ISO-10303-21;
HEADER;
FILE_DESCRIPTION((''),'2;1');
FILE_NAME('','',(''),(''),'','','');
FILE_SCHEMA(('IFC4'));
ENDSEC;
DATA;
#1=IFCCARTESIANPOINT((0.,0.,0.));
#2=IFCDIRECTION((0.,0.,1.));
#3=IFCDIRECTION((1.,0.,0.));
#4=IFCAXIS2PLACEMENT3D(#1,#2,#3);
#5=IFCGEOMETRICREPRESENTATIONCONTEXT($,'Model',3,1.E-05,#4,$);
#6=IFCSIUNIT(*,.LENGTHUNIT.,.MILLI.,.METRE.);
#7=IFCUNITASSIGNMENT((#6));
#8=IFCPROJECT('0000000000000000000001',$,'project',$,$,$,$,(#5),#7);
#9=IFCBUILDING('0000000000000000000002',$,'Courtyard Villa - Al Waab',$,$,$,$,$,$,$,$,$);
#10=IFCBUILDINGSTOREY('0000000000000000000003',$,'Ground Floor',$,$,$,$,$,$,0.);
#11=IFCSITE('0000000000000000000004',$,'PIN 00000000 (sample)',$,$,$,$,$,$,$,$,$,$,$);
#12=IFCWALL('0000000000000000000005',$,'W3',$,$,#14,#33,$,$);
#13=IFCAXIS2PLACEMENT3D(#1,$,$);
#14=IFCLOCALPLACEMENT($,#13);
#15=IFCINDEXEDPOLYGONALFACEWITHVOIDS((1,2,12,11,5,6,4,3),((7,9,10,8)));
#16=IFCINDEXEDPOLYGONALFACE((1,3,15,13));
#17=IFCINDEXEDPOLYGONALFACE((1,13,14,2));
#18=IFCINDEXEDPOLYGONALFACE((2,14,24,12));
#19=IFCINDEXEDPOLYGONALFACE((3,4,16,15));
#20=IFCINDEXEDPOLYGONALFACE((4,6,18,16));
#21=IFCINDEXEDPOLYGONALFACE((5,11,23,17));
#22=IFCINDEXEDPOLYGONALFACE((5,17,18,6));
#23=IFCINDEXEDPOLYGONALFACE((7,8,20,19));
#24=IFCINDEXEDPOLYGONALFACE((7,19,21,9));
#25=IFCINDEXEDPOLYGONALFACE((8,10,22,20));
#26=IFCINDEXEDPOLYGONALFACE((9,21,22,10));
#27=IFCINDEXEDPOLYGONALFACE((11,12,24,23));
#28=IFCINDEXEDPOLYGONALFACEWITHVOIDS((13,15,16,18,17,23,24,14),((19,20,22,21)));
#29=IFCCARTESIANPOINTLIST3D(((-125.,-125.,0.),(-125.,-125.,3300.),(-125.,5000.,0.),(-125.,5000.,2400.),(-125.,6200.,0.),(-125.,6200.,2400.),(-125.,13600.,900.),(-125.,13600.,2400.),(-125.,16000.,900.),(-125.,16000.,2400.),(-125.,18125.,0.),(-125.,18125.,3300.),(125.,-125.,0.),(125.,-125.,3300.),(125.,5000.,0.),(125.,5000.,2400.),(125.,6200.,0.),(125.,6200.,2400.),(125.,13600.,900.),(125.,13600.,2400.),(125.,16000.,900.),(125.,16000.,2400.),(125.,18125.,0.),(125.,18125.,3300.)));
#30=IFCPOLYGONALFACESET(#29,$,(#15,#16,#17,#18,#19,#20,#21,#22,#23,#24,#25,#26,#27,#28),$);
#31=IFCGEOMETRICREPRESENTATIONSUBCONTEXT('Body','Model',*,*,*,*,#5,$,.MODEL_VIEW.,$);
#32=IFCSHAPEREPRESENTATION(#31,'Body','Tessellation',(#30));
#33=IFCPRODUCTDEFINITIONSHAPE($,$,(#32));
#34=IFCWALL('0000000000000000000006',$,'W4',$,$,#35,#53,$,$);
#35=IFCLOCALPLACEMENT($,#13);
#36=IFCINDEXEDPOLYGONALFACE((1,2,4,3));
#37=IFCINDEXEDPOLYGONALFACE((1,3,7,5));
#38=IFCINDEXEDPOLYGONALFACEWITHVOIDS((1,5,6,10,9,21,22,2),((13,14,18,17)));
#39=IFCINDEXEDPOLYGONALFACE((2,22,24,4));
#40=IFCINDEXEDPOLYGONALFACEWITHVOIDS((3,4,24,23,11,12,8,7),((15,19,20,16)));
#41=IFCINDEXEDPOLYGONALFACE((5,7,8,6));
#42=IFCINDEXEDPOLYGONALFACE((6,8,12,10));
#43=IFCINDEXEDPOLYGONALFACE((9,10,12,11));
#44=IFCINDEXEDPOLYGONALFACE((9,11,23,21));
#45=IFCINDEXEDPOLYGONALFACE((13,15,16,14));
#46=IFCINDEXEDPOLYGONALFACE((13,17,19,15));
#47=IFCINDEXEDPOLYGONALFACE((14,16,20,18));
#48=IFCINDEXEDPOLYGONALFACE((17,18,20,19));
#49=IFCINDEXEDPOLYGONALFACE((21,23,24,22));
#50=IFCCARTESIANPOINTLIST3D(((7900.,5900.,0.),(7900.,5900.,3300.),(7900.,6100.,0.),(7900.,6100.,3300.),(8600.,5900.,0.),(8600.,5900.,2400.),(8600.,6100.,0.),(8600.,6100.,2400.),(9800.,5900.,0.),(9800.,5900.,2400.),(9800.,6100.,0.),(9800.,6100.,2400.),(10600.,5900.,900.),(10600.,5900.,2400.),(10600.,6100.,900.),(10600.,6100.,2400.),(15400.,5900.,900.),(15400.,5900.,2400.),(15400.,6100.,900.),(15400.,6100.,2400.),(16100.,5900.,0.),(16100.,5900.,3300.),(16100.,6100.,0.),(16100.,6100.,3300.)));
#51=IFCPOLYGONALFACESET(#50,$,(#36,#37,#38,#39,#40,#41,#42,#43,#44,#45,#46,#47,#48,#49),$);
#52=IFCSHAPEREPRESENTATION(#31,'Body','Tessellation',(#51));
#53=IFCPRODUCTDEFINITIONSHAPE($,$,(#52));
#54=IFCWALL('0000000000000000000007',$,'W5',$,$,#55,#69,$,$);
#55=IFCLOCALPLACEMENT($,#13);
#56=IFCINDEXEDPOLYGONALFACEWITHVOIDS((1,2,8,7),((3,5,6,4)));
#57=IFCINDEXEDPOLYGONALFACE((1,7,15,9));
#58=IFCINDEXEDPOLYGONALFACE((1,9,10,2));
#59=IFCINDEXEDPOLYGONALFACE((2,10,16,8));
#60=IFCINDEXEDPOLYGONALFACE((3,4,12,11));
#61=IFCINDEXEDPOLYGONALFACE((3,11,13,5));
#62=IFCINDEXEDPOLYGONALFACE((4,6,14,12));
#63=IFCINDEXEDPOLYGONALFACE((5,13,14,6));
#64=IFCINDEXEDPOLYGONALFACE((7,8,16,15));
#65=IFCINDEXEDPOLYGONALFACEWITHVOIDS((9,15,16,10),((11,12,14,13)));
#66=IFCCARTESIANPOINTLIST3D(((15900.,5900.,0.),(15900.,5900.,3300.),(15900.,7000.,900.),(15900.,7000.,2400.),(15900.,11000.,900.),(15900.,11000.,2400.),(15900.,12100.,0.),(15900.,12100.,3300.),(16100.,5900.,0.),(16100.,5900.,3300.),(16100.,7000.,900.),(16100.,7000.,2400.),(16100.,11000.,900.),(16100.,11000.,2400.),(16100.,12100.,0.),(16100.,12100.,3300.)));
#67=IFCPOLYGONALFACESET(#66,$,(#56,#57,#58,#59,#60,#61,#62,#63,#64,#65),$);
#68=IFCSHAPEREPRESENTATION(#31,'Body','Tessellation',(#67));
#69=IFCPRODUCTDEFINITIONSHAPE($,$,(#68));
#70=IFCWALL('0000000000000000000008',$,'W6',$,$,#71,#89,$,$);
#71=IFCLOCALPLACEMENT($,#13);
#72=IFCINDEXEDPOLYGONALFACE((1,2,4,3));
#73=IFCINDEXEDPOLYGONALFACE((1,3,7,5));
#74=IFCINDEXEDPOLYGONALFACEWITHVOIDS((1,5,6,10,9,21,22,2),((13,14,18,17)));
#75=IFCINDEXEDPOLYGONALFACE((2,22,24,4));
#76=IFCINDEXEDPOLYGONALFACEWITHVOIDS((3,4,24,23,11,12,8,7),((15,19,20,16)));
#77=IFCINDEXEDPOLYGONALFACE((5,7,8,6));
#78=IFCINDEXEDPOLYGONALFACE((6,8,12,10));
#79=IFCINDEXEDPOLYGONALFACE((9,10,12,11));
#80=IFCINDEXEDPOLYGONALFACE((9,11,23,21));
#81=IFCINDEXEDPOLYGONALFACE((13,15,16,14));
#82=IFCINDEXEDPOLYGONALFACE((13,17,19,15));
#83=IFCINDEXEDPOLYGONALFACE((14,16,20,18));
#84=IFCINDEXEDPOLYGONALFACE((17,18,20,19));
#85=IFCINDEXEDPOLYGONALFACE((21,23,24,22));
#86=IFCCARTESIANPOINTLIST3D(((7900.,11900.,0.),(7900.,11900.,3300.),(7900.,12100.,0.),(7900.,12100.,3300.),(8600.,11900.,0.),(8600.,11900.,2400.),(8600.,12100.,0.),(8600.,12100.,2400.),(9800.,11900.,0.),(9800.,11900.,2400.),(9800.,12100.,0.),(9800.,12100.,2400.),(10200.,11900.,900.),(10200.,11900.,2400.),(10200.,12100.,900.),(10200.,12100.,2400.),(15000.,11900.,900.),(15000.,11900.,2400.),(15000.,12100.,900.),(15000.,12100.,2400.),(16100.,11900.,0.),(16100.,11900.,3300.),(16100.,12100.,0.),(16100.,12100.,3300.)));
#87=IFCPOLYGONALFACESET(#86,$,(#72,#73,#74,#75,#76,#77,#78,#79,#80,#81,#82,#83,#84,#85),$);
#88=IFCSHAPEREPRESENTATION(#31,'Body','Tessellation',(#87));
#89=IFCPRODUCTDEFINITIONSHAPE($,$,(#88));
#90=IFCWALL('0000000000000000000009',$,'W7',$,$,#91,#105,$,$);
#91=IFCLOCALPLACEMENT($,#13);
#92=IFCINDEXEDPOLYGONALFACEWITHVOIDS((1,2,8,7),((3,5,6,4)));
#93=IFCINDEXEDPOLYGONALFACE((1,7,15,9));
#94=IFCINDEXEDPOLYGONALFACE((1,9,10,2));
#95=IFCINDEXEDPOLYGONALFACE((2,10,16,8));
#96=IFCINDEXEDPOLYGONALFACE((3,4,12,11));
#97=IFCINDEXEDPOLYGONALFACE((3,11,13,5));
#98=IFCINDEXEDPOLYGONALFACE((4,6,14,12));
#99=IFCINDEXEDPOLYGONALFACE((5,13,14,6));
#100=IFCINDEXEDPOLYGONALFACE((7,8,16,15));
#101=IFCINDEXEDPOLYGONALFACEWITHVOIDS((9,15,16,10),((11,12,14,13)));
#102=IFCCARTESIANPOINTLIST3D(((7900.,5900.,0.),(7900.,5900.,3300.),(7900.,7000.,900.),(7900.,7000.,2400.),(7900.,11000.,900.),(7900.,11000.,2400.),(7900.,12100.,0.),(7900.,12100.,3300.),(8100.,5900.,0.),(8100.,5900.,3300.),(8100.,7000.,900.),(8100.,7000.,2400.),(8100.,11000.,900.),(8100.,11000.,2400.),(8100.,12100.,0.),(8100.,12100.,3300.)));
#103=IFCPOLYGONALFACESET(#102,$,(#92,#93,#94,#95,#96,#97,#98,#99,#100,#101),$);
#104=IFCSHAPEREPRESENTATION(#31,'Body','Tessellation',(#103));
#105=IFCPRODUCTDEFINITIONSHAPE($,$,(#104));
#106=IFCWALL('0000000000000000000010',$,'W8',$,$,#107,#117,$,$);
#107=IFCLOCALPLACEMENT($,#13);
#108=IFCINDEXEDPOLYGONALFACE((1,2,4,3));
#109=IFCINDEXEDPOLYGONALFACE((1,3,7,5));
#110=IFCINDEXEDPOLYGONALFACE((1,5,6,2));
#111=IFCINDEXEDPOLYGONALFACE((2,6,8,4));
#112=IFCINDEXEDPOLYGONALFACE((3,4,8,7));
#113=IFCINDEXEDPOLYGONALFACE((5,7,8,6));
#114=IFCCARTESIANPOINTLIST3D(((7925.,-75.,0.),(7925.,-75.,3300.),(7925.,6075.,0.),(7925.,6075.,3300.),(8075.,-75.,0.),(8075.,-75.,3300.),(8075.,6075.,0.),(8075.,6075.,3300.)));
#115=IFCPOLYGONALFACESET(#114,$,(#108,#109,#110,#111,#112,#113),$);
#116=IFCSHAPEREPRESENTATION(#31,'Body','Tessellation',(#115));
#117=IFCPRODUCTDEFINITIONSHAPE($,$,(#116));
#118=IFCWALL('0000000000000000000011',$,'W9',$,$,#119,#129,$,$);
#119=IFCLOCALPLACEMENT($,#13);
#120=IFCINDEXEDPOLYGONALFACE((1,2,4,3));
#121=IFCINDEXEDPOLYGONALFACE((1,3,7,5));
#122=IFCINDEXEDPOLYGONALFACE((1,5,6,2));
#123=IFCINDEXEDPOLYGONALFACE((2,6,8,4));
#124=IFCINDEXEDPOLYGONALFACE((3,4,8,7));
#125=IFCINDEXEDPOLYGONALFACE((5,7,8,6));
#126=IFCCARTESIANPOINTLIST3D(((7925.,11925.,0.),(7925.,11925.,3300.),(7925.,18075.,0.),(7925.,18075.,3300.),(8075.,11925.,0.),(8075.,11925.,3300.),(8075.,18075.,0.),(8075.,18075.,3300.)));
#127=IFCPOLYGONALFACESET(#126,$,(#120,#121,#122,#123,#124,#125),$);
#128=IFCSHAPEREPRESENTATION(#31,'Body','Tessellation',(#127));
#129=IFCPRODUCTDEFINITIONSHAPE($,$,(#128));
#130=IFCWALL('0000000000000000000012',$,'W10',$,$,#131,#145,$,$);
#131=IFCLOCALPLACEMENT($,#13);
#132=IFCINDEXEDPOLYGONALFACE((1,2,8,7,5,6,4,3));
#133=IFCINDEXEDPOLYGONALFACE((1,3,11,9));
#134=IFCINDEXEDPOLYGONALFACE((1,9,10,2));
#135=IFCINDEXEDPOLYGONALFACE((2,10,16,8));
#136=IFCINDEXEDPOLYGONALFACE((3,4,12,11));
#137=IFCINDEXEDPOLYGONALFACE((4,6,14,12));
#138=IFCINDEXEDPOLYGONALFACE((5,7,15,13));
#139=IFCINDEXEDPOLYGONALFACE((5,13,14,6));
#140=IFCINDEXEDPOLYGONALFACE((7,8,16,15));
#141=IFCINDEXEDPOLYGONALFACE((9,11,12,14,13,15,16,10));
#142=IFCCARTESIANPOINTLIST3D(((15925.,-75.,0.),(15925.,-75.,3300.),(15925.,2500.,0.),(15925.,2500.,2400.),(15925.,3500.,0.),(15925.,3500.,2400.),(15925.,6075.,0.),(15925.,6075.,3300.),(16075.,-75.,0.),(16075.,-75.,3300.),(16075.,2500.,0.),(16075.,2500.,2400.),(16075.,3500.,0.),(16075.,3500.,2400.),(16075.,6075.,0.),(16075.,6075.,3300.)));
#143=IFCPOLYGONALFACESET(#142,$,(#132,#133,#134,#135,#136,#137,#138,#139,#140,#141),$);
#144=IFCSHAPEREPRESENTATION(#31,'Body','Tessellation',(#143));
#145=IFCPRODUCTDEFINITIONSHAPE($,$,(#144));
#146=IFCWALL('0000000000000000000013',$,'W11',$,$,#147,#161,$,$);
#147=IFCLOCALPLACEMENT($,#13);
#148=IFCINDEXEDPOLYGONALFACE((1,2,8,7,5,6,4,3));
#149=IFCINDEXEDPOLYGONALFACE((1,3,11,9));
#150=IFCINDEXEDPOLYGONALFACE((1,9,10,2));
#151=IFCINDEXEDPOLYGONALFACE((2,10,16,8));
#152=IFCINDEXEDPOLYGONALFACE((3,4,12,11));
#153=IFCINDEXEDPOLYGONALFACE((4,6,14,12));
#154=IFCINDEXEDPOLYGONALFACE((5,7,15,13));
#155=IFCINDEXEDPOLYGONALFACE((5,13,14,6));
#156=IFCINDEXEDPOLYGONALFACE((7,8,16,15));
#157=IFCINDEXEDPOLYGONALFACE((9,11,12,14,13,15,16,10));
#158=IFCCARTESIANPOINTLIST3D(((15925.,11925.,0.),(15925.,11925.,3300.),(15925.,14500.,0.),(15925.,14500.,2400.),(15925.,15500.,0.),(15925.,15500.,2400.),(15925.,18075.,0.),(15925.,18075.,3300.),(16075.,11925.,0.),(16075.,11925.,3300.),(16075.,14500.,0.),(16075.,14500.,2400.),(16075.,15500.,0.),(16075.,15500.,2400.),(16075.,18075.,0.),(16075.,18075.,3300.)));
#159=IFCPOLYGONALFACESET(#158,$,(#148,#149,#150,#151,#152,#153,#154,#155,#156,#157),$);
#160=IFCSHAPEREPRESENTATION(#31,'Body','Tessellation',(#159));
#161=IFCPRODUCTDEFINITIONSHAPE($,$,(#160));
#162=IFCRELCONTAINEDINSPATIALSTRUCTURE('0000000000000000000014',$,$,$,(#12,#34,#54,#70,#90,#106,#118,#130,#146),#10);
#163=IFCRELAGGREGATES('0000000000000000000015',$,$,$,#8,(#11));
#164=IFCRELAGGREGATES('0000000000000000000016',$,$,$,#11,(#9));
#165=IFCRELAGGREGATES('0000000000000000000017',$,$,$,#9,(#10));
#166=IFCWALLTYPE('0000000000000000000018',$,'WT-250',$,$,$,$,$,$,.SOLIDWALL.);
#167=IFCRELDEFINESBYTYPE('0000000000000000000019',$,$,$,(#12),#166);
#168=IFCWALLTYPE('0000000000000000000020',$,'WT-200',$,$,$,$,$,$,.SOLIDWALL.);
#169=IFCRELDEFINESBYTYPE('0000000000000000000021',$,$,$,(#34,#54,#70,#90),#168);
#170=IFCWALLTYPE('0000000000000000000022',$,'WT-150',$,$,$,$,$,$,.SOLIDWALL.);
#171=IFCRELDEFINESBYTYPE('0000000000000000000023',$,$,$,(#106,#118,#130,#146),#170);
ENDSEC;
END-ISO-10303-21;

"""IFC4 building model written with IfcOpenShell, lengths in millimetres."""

from ifc_helpers import new_model, si_unit, frame, origin_with_axes, place, context, subcontext, project, spatial, indexed_curve, outline, extrude, type_object, element, save


model = new_model("IFC4")

# Units and contexts
model_context = context("Model", 3, precision=1e-05, world=origin_with_axes())
body_context = subcontext(model_context, "Body", "Model", "MODEL_VIEW")
ifc_project = project(units=[si_unit("LENGTHUNIT", "METRE", prefix="MILLI")], contexts=[model_context])

# Site, building, storey
site = spatial("IfcSite", under=ifc_project, Name="PIN 00000000 (sample)")
building = spatial("IfcBuilding", under=site, Name="Courtyard Villa - Al Waab")
storey = spatial("IfcBuildingStorey", under=building, Name="Ground Floor", Elevation=0.0)

# Walls, openings
wall_type_1 = type_object("IfcWallType", Name="WT-250", PredefinedType="SOLIDWALL")
wall_1_placement = place(None, frame((-125.0, 18125.0, 0.0), z_axis=(0.0, 0.0, 1.0), x_axis=(0.0, -1.0, 0.0)))
wall_1 = element("IfcWall", 1, at=wall_1_placement, inside=storey, type_object=wall_type_1, Name="W3", context=body_context, shape_type="SweptSolid", body=[
    extrude(outline(indexed_curve([(0.0, 0.0), (0.0, 250.0), (18250.0, 250.0), (18250.0, 0.0), (0.0, 0.0)], self_intersect=False)), origin_with_axes(), (0.0, 0.0, 1.0), 3300.0),
])
opening_1_placement = place(wall_1_placement, frame((2125.0, -100.0, 900.0), z_axis=(0.0, 0.0, 1.0), x_axis=(1.0, 0.0, 0.0)))
element("IfcOpeningElement", 2, at=opening_1_placement, cuts=wall_1, context=body_context, shape_type="SweptSolid", body=[
    extrude(outline(indexed_curve([(0.0, 0.0), (0.0, 450.0), (2400.0, 450.0), (2400.0, 0.0), (0.0, 0.0)], self_intersect=False)), origin_with_axes(), (0.0, 0.0, 1.0), 1500.0),
])
opening_2_placement = place(wall_1_placement, frame((11925.0, -100.0, 0.0), z_axis=(0.0, 0.0, 1.0), x_axis=(1.0, 0.0, 0.0)))
element("IfcOpeningElement", 3, at=opening_2_placement, cuts=wall_1, context=body_context, shape_type="SweptSolid", body=[
    extrude(outline(indexed_curve([(0.0, 0.0), (0.0, 450.0), (1200.0, 450.0), (1200.0, 0.0), (0.0, 0.0)], self_intersect=False)), origin_with_axes(), (0.0, 0.0, 1.0), 2400.0),
])
wall_type_2 = type_object("IfcWallType", Name="WT-200", PredefinedType="SOLIDWALL")
wall_2_placement = place(None, frame((7900.0, 5900.0, 0.0), z_axis=(0.0, 0.0, 1.0), x_axis=(1.0, 0.0, 0.0)))
wall_2 = element("IfcWall", 4, at=wall_2_placement, inside=storey, type_object=wall_type_2, Name="W4", context=body_context, shape_type="SweptSolid", body=[
    extrude(outline(indexed_curve([(0.0, 0.0), (0.0, 200.0), (8200.0, 200.0), (8200.0, 0.0), (0.0, 0.0)], self_intersect=False)), origin_with_axes(), (0.0, 0.0, 1.0), 3300.0),
])
opening_3_placement = place(wall_2_placement, frame((700.0, -100.0, 0.0), z_axis=(0.0, 0.0, 1.0), x_axis=(1.0, 0.0, 0.0)))
element("IfcOpeningElement", 5, at=opening_3_placement, cuts=wall_2, context=body_context, shape_type="SweptSolid", body=[
    extrude(outline(indexed_curve([(0.0, 0.0), (0.0, 400.0), (1200.0, 400.0), (1200.0, 0.0), (0.0, 0.0)], self_intersect=False)), origin_with_axes(), (0.0, 0.0, 1.0), 2400.0),
])
opening_4_placement = place(wall_2_placement, frame((2700.0, -100.0, 900.0), z_axis=(0.0, 0.0, 1.0), x_axis=(1.0, 0.0, 0.0)))
element("IfcOpeningElement", 6, at=opening_4_placement, cuts=wall_2, context=body_context, shape_type="SweptSolid", body=[
    extrude(outline(indexed_curve([(0.0, 0.0), (0.0, 400.0), (4800.0, 400.0), (4800.0, 0.0), (0.0, 0.0)], self_intersect=False)), origin_with_axes(), (0.0, 0.0, 1.0), 1500.0),
])

# Wall, opening
wall_3_placement = place(None, frame((16100.0, 5900.0, 0.0), z_axis=(0.0, 0.0, 1.0), x_axis=(0.0, 1.0, 0.0)))
wall_3 = element("IfcWall", 7, at=wall_3_placement, inside=storey, type_object=wall_type_2, Name="W5", context=body_context, shape_type="SweptSolid", body=[
    extrude(outline(indexed_curve([(0.0, 0.0), (0.0, 200.0), (6200.0, 200.0), (6200.0, 0.0), (0.0, 0.0)], self_intersect=False)), origin_with_axes(), (0.0, 0.0, 1.0), 3300.0),
])
opening_5_placement = place(wall_3_placement, frame((1100.0, -100.0, 900.0), z_axis=(0.0, 0.0, 1.0), x_axis=(1.0, 0.0, 0.0)))
element("IfcOpeningElement", 8, at=opening_5_placement, cuts=wall_3, context=body_context, shape_type="SweptSolid", body=[
    extrude(outline(indexed_curve([(0.0, 0.0), (0.0, 400.0), (4000.0, 400.0), (4000.0, 0.0), (0.0, 0.0)], self_intersect=False)), origin_with_axes(), (0.0, 0.0, 1.0), 1500.0),
])

# Wall, openings
wall_4_placement = place(None, frame((16100.0, 12100.0, 0.0), z_axis=(0.0, 0.0, 1.0), x_axis=(-1.0, 0.0, 0.0)))
wall_4 = element("IfcWall", 9, at=wall_4_placement, inside=storey, type_object=wall_type_2, Name="W6", context=body_context, shape_type="SweptSolid", body=[
    extrude(outline(indexed_curve([(0.0, 0.0), (0.0, 200.0), (8200.0, 200.0), (8200.0, 0.0), (0.0, 0.0)], self_intersect=False)), origin_with_axes(), (0.0, 0.0, 1.0), 3300.0),
])
opening_6_placement = place(wall_4_placement, frame((1100.0, -100.0, 900.0), z_axis=(0.0, 0.0, 1.0), x_axis=(1.0, 0.0, 0.0)))
element("IfcOpeningElement", 10, at=opening_6_placement, cuts=wall_4, context=body_context, shape_type="SweptSolid", body=[
    extrude(outline(indexed_curve([(0.0, 0.0), (0.0, 400.0), (4800.0, 400.0), (4800.0, 0.0), (0.0, 0.0)], self_intersect=False)), origin_with_axes(), (0.0, 0.0, 1.0), 1500.0),
])
opening_7_placement = place(wall_4_placement, frame((6300.0, -100.0, 0.0), z_axis=(0.0, 0.0, 1.0), x_axis=(1.0, 0.0, 0.0)))
element("IfcOpeningElement", 11, at=opening_7_placement, cuts=wall_4, context=body_context, shape_type="SweptSolid", body=[
    extrude(outline(indexed_curve([(0.0, 0.0), (0.0, 400.0), (1200.0, 400.0), (1200.0, 0.0), (0.0, 0.0)], self_intersect=False)), origin_with_axes(), (0.0, 0.0, 1.0), 2400.0),
])

# Wall, opening
wall_5_placement = place(None, frame((7900.0, 12100.0, 0.0), z_axis=(0.0, 0.0, 1.0), x_axis=(0.0, -1.0, 0.0)))
wall_5 = element("IfcWall", 12, at=wall_5_placement, inside=storey, type_object=wall_type_2, Name="W7", context=body_context, shape_type="SweptSolid", body=[
    extrude(outline(indexed_curve([(0.0, 0.0), (0.0, 200.0), (6200.0, 200.0), (6200.0, 0.0), (0.0, 0.0)], self_intersect=False)), origin_with_axes(), (0.0, 0.0, 1.0), 3300.0),
])
opening_8_placement = place(wall_5_placement, frame((1100.0, -100.0, 900.0), z_axis=(0.0, 0.0, 1.0), x_axis=(1.0, 0.0, 0.0)))
element("IfcOpeningElement", 13, at=opening_8_placement, cuts=wall_5, context=body_context, shape_type="SweptSolid", body=[
    extrude(outline(indexed_curve([(0.0, 0.0), (0.0, 400.0), (4000.0, 400.0), (4000.0, 0.0), (0.0, 0.0)], self_intersect=False)), origin_with_axes(), (0.0, 0.0, 1.0), 1500.0),
])

# Walls
wall_type_3 = type_object("IfcWallType", Name="WT-150", PredefinedType="SOLIDWALL")
for number, where, z_axis, x_axis, name in (
    (14, (8075.0, -75.0, 0.0), (0.0, 0.0, 1.0), (0.0, 1.0, 0.0), "W8"),
    (15, (8075.0, 11925.0, 0.0), (0.0, 0.0, 1.0), (0.0, 1.0, 0.0), "W9"),
):
    element("IfcWall", number, at=place(None, frame(where, z_axis=z_axis, x_axis=x_axis)), inside=storey, type_object=wall_type_3, Name=name, context=body_context, shape_type="SweptSolid", body=[
        extrude(outline(indexed_curve([(0.0, 0.0), (0.0, 150.0), (6150.0, 150.0), (6150.0, 0.0), (0.0, 0.0)], self_intersect=False)), origin_with_axes(), (0.0, 0.0, 1.0), 3300.0),
    ])

# Walls, openings
wall_6_placement = place(None, frame((16075.0, -75.0, 0.0), z_axis=(0.0, 0.0, 1.0), x_axis=(0.0, 1.0, 0.0)))
wall_6 = element("IfcWall", 16, at=wall_6_placement, inside=storey, type_object=wall_type_3, Name="W10", context=body_context, shape_type="SweptSolid", body=[
    extrude(outline(indexed_curve([(0.0, 0.0), (0.0, 150.0), (6150.0, 150.0), (6150.0, 0.0), (0.0, 0.0)], self_intersect=False)), origin_with_axes(), (0.0, 0.0, 1.0), 3300.0),
])
opening_9_placement = place(wall_6_placement, frame((2575.0, -100.0, 0.0), z_axis=(0.0, 0.0, 1.0), x_axis=(1.0, 0.0, 0.0)))
element("IfcOpeningElement", 17, at=opening_9_placement, cuts=wall_6, context=body_context, shape_type="SweptSolid", body=[
    extrude(outline(indexed_curve([(0.0, 0.0), (0.0, 350.0), (1000.0, 350.0), (1000.0, 0.0), (0.0, 0.0)], self_intersect=False)), origin_with_axes(), (0.0, 0.0, 1.0), 2400.0),
])
wall_7_placement = place(None, frame((16075.0, 11925.0, 0.0), z_axis=(0.0, 0.0, 1.0), x_axis=(0.0, 1.0, 0.0)))
wall_7 = element("IfcWall", 18, at=wall_7_placement, inside=storey, type_object=wall_type_3, Name="W11", context=body_context, shape_type="SweptSolid", body=[
    extrude(outline(indexed_curve([(0.0, 0.0), (0.0, 150.0), (6150.0, 150.0), (6150.0, 0.0), (0.0, 0.0)], self_intersect=False)), origin_with_axes(), (0.0, 0.0, 1.0), 3300.0),
])
opening_10_placement = place(wall_7_placement, frame((2575.0, -100.0, 0.0), z_axis=(0.0, 0.0, 1.0), x_axis=(1.0, 0.0, 0.0)))
element("IfcOpeningElement", 19, at=opening_10_placement, cuts=wall_7, context=body_context, shape_type="SweptSolid", body=[
    extrude(outline(indexed_curve([(0.0, 0.0), (0.0, 350.0), (1000.0, 350.0), (1000.0, 0.0), (0.0, 0.0)], self_intersect=False)), origin_with_axes(), (0.0, 0.0, 1.0), 2400.0),
])

save(model, "model.ifc")
